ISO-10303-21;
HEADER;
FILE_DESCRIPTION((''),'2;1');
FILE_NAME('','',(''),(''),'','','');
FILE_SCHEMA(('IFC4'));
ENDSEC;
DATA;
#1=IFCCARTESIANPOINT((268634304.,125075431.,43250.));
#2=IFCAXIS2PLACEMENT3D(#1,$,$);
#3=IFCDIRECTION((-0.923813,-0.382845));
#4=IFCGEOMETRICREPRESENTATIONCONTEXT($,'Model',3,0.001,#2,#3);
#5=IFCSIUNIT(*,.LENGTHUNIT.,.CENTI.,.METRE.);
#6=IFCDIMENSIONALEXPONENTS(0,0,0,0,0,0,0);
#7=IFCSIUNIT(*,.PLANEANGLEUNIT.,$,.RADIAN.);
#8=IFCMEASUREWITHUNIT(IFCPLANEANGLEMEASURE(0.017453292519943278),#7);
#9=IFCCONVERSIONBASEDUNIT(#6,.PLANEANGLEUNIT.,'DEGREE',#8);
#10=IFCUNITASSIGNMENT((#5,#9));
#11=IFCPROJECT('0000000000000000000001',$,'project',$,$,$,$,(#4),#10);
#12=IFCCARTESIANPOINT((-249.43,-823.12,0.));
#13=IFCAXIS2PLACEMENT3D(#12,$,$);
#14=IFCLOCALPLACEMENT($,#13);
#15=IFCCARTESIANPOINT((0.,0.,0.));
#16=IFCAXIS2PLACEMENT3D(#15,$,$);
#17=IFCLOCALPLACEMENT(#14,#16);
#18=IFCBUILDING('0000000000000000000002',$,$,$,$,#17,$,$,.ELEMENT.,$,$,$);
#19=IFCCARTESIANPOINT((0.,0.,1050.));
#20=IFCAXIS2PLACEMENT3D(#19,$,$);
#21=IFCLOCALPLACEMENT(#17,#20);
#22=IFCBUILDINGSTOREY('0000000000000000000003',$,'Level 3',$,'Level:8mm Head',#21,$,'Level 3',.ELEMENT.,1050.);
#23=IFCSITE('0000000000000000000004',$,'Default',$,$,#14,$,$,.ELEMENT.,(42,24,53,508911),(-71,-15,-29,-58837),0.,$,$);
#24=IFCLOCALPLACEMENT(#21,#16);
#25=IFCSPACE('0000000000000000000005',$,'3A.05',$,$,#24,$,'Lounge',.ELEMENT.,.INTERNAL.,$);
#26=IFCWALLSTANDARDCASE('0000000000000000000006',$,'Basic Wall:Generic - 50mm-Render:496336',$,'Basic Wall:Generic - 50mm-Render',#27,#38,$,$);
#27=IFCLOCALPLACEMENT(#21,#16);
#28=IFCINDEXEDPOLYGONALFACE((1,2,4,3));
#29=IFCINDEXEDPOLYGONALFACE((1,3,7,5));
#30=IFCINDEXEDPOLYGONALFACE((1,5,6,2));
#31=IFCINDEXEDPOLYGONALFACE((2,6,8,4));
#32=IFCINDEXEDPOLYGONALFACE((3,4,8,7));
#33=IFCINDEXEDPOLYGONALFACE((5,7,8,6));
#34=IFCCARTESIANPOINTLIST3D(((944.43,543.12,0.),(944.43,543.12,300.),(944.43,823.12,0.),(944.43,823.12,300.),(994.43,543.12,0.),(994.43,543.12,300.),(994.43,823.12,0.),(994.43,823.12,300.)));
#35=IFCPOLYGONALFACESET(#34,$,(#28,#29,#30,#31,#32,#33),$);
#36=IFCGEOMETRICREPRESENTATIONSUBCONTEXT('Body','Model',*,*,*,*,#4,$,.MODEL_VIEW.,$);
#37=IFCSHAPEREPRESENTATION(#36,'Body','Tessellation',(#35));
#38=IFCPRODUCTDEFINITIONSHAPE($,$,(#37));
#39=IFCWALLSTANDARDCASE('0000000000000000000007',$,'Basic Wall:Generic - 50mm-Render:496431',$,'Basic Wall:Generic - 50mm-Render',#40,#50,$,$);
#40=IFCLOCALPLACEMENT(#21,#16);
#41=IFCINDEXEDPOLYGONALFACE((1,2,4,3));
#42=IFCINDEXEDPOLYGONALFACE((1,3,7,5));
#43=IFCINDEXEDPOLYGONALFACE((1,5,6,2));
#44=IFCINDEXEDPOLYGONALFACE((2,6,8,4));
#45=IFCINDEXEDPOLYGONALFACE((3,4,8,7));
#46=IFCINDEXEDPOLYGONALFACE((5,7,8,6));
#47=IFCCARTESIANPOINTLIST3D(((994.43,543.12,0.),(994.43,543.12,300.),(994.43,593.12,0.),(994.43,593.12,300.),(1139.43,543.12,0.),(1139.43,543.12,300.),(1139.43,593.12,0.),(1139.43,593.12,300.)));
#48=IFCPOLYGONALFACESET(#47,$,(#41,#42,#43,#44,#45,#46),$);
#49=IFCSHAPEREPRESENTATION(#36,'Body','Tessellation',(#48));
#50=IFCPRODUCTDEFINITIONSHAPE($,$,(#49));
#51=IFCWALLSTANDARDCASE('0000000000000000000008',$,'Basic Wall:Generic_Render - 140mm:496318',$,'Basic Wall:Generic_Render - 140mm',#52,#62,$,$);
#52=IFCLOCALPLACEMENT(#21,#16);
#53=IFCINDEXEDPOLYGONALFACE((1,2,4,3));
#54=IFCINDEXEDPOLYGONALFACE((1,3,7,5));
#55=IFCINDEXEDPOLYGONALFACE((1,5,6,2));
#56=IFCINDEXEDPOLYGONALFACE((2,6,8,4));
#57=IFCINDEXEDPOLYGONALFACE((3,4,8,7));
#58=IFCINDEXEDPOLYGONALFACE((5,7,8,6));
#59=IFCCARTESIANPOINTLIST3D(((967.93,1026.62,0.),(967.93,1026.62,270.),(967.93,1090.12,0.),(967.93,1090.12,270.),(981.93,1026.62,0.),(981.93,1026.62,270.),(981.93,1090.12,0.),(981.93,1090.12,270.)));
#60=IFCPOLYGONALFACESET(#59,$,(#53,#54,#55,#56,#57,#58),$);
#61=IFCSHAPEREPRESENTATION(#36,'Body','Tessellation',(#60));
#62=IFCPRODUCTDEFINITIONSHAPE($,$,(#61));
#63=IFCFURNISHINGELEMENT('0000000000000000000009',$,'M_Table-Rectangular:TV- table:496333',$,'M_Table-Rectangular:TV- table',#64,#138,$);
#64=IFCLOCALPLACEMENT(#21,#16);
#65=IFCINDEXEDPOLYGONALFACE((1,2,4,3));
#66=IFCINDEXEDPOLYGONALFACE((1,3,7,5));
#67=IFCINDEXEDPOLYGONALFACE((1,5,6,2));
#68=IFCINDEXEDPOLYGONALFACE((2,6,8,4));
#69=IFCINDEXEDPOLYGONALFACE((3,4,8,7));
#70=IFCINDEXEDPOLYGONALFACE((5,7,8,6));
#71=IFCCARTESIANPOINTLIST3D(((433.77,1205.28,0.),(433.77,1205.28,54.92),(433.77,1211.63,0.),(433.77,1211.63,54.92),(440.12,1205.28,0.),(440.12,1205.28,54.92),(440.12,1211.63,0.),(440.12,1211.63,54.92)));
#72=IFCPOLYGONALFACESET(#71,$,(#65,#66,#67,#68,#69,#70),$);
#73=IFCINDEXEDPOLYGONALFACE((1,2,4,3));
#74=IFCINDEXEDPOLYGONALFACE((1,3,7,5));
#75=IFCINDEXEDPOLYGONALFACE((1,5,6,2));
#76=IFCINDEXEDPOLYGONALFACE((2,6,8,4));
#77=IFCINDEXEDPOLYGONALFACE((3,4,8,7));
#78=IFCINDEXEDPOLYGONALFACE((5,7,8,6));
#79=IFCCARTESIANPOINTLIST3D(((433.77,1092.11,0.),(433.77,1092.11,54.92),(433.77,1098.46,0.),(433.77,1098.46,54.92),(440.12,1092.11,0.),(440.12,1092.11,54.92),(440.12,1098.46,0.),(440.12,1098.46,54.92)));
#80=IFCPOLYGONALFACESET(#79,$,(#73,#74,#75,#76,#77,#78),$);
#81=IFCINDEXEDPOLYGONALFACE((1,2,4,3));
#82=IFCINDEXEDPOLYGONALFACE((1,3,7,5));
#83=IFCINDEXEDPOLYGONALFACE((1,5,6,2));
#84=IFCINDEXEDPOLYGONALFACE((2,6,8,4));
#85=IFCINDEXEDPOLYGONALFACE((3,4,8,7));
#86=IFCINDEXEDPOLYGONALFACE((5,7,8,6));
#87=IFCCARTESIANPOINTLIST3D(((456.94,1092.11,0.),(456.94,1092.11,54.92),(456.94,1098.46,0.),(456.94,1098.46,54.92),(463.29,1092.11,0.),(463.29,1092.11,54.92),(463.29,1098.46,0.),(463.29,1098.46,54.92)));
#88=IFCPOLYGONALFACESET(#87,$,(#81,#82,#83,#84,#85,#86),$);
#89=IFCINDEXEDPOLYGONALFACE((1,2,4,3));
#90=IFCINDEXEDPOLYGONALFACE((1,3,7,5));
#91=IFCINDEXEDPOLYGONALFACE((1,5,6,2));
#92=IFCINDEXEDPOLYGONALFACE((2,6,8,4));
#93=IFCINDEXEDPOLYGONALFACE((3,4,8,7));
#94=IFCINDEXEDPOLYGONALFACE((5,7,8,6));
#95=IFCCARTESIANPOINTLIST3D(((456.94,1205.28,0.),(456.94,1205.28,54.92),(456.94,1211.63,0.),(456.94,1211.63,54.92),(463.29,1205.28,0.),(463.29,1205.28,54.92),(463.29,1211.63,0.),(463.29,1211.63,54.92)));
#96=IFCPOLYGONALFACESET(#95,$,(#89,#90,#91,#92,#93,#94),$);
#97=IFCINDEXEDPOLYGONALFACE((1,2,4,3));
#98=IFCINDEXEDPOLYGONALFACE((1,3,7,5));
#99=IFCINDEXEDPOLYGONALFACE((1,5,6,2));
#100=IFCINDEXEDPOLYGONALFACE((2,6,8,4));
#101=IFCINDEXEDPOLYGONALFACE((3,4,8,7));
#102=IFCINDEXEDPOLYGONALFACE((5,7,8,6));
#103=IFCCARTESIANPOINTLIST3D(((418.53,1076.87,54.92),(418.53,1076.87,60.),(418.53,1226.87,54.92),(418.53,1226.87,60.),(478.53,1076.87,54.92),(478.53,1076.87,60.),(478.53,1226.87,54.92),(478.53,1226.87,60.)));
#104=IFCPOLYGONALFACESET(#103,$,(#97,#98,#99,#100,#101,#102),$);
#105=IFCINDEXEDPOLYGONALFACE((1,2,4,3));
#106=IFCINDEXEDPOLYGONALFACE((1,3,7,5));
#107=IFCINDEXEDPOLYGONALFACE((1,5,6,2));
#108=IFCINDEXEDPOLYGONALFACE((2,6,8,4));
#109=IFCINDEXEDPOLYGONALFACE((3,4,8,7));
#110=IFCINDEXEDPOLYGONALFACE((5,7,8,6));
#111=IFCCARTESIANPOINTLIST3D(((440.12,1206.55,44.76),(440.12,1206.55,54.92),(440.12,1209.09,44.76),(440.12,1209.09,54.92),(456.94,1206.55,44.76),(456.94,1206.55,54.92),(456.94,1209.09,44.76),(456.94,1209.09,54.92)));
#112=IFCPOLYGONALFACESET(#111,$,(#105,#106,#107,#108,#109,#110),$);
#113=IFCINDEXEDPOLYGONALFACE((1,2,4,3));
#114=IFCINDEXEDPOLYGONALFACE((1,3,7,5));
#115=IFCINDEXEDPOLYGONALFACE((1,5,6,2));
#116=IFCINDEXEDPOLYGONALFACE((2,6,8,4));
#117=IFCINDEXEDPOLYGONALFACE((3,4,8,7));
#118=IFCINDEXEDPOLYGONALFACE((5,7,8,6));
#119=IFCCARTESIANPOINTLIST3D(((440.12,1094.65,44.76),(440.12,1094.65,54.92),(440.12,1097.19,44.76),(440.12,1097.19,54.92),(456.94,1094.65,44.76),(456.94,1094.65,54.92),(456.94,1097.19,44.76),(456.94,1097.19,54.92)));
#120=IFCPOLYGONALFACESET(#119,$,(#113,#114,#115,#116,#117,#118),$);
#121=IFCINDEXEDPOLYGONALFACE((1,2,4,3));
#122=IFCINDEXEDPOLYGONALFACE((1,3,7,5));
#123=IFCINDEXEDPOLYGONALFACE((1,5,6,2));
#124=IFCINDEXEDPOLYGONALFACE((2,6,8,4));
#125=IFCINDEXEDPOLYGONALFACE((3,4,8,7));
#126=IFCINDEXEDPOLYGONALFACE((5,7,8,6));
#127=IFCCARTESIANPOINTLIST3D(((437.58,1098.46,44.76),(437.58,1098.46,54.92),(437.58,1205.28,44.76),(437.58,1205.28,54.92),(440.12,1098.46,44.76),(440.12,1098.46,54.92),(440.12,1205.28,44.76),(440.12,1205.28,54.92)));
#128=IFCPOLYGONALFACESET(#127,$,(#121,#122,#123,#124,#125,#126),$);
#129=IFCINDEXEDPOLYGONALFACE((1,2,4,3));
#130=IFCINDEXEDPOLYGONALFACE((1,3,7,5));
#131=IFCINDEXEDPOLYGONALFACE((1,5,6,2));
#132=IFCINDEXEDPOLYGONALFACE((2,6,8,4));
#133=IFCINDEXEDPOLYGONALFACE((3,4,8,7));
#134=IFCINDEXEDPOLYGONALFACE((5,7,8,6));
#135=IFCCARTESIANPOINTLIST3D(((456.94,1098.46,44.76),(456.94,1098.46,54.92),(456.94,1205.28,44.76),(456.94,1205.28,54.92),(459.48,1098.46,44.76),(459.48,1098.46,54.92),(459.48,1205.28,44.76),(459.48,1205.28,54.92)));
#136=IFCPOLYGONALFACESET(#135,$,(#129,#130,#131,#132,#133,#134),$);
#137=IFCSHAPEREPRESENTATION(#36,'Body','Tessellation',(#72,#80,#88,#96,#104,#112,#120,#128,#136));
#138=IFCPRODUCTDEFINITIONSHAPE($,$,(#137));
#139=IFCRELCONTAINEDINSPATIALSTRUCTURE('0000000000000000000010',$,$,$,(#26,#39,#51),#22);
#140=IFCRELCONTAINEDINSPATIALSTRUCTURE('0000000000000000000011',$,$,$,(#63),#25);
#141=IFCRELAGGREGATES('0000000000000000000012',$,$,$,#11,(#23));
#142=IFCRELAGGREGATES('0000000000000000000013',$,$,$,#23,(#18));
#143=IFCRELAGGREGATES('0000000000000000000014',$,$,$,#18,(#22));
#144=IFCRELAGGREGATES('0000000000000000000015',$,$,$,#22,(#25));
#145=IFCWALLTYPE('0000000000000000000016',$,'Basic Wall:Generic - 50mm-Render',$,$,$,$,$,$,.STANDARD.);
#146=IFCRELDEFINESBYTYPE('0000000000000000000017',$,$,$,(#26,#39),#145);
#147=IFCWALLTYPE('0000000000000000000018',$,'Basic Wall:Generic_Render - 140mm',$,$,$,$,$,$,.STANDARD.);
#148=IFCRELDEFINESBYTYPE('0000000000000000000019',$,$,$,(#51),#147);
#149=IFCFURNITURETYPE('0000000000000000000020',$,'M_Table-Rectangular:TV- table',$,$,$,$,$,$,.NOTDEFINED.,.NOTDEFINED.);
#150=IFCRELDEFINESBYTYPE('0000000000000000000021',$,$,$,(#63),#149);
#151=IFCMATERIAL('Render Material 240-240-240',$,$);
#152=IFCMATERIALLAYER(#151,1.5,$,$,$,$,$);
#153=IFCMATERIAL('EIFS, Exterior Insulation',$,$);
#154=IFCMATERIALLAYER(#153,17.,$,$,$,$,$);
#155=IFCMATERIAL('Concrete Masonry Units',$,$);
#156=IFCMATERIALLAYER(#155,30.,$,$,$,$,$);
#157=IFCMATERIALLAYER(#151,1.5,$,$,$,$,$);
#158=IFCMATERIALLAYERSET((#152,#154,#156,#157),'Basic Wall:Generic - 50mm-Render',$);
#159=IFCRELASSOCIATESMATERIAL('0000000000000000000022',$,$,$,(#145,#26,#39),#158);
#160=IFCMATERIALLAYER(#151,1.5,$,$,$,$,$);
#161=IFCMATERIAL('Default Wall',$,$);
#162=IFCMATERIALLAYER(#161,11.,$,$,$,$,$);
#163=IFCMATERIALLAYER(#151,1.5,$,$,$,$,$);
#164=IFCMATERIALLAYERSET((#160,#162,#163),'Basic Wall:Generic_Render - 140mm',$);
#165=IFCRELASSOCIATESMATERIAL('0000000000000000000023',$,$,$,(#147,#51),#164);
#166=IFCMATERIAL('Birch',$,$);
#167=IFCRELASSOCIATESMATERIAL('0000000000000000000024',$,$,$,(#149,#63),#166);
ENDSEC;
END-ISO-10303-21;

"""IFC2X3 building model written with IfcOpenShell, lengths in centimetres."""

from ifc_helpers import new_model, entity, si_unit, converted_unit, direction, frame, frame_2d, origin, origin_2d_with_axis, place, context, subcontext, project, spatial, rectangle, extrude, source, transform, mapped, material, layer, layer_set, layer_usage, type_object, type_shapes, element, save


model = new_model("IFC2X3")

# Units and contexts
model_context = context("Model", 3, precision=0.001, world=frame((268634304.0, 125075431.0, 43250.0)), true_north=direction((-0.923813, -0.382845)))
body_context = subcontext(model_context, "Body", "Model", "MODEL_VIEW")
ifc_project = project(units=[si_unit("LENGTHUNIT", "METRE", prefix="CENTI"), converted_unit("PLANEANGLEUNIT", "DEGREE", entity("IfcPlaneAngleMeasure", 0.017453292519943278), si_unit("PLANEANGLEUNIT", "RADIAN"), dimensions=[0, 0, 0, 0, 0, 0, 0])], contexts=[model_context])

# Site, building, storey
site_placement = place(None, frame((-249.43, -823.12, 0.0)))
site = spatial("IfcSite", under=ifc_project, at=site_placement, Name="Default", CompositionType="ELEMENT", RefLatitude=(42, 24, 53, 508911), RefLongitude=(-71, -15, -29, -58837), RefElevation=0.0)
building_placement = place(site_placement, origin())
building = spatial("IfcBuilding", under=site, at=building_placement, CompositionType="ELEMENT")
storey_placement = place(building_placement, frame((0.0, 0.0, 1050.0)))
storey = spatial("IfcBuildingStorey", under=building, at=storey_placement, Name="Level 3", ObjectType="Level:8mm Head", LongName="Level 3", CompositionType="ELEMENT", Elevation=1050.0)

# Walls
ifc_material_1 = material(Name="Render Material 240-240-240")
ifc_layer_1 = layer(ifc_material_1, 1.5)
ifc_material_2 = material(Name="EIFS, Exterior Insulation")
ifc_layer_2 = layer(ifc_material_2, 17.0)
ifc_material_3 = material(Name="Concrete Masonry Units")
ifc_layer_3 = layer(ifc_material_3, 30.0)
ifc_layer_4 = layer(ifc_material_1, 1.5)
ifc_layer_set_1 = layer_set([ifc_layer_1, ifc_layer_2, ifc_layer_3, ifc_layer_4], Name="Basic Wall:Generic - 50mm-Render")
ifc_layer_usage_1 = layer_usage(ifc_layer_set_1, "AXIS2", "POSITIVE", -25.0)
wall_type_1 = type_object("IfcWallType", Name="Basic Wall:Generic - 50mm-Render", PredefinedType="STANDARD", material=ifc_layer_set_1)
wall_1_placement = place(storey_placement, frame((969.43, 823.12, 0.0), z_axis=(0.0, 0.0, 1.0), x_axis=(0.0, -1.0, 0.0)))
element("IfcWallStandardCase", 1, at=wall_1_placement, inside=storey, type_object=wall_type_1, material=ifc_layer_usage_1, Name="Basic Wall:Generic - 50mm-Render:496336", ObjectType="Basic Wall:Generic - 50mm-Render", context=body_context, shape_type="SweptSolid", body=[
    extrude(rectangle(XDim=280.0, YDim=50.0, at=frame_2d((140.0, 0.0), x_axis=(-1.0, 0.0))), origin(), (0.0, 0.0, 1.0), 300.0),
])
ifc_layer_usage_2 = layer_usage(ifc_layer_set_1, "AXIS2", "NEGATIVE", 25.0)
wall_2_placement = place(storey_placement, frame((1139.43, 568.12, 0.0), z_axis=(0.0, 0.0, 1.0), x_axis=(-1.0, 0.0, 0.0)))
element("IfcWallStandardCase", 2, at=wall_2_placement, inside=storey, type_object=wall_type_1, material=ifc_layer_usage_2, Name="Basic Wall:Generic - 50mm-Render:496431", ObjectType="Basic Wall:Generic - 50mm-Render", context=body_context, shape_type="SweptSolid", body=[
    extrude(rectangle(XDim=145.0, YDim=50.0, at=frame_2d((72.5, 0.0), x_axis=(-1.0, 0.0))), origin(), (0.0, 0.0, 1.0), 300.0),
])
ifc_layer_5 = layer(ifc_material_1, 1.5)
ifc_material_4 = material(Name="Default Wall")
ifc_layer_6 = layer(ifc_material_4, 11.0)
ifc_layer_7 = layer(ifc_material_1, 1.5)
ifc_layer_set_2 = layer_set([ifc_layer_5, ifc_layer_6, ifc_layer_7], Name="Basic Wall:Generic_Render - 140mm")
ifc_layer_usage_3 = layer_usage(ifc_layer_set_2, "AXIS2", "NEGATIVE", 7.0)
wall_type_2 = type_object("IfcWallType", Name="Basic Wall:Generic_Render - 140mm", PredefinedType="STANDARD", material=ifc_layer_set_2)
wall_3_placement = place(storey_placement, frame((974.93, 1090.12, 0.0), z_axis=(0.0, 0.0, 1.0), x_axis=(0.0, -1.0, 0.0)))
element("IfcWallStandardCase", 3, at=wall_3_placement, inside=storey, type_object=wall_type_2, material=ifc_layer_usage_3, Name="Basic Wall:Generic_Render - 140mm:496318", ObjectType="Basic Wall:Generic_Render - 140mm", context=body_context, shape_type="SweptSolid", body=[
    extrude(rectangle(XDim=63.5, YDim=14.0, at=frame_2d((31.75, 0.0), x_axis=(-1.0, 0.0))), origin(), (0.0, 0.0, 1.0), 270.0),
])

# Shared definitions
space_1_placement = place(storey_placement, origin())
space_1 = spatial("IfcSpace", under=storey, at=space_1_placement, Name="3A.05", LongName="Lounge", CompositionType="ELEMENT", InteriorOrExteriorSpace="INTERNAL")

# Furnishing element
ifc_material_5 = material(Name="Birch")
furniture_type_1 = type_object("IfcFurnitureType", Name="M_Table-Rectangular:TV- table", AssemblyPlace="NOTDEFINED", material=ifc_material_5)
shared_shape_1 = source(origin(), body_context, "Body", "SweptSolid", [
    extrude(rectangle(XDim=6.35, YDim=6.35, at=origin_2d_with_axis()), frame((56.58, 11.59, 0.0), z_axis=(0.0, 0.0, 1.0), x_axis=(0.0, -1.0, 0.0)), (0.0, 0.0, 1.0), 54.92),
    extrude(rectangle(XDim=6.35, YDim=6.35, at=frame_2d((0.0, 0.0), x_axis=(1.0, 0.0))), frame((-56.58, 11.59, 0.0), z_axis=(0.0, 0.0, 1.0), x_axis=(-1.0, 0.0, 0.0)), (0.0, 0.0, 1.0), 54.92),
    extrude(rectangle(XDim=6.35, YDim=6.35, at=origin_2d_with_axis()), frame((-56.58, -11.59, 0.0), z_axis=(0.0, 0.0, 1.0), x_axis=(0.0, 1.0, 0.0)), (0.0, 0.0, 1.0), 54.92),
    extrude(rectangle(XDim=6.35, YDim=6.35, at=origin_2d_with_axis()), frame((56.58, -11.59, 0.0)), (0.0, 0.0, 1.0), 54.92),
    extrude(rectangle(XDim=150.0, YDim=60.0, at=origin_2d_with_axis()), frame((0.0, 0.0, 54.92), z_axis=(0.0, 0.0, 1.0), x_axis=(-1.0, 0.0, 0.0)), (0.0, 0.0, 1.0), 5.08),
    extrude(rectangle(XDim=2.54, YDim=16.82, at=origin_2d_with_axis()), frame((55.95, 0.0, 44.76)), (0.0, 0.0, 1.0), 10.16),
    extrude(rectangle(XDim=16.82, YDim=2.54, at=origin_2d_with_axis()), frame((-55.95, 0.0, 44.76), z_axis=(0.0, 0.0, 1.0), x_axis=(0.0, 1.0, 0.0)), (0.0, 0.0, 1.0), 10.16),
    extrude(rectangle(XDim=106.82, YDim=2.54, at=frame_2d((0.0, 0.0), x_axis=(1.0, 0.0))), frame((0.0, 9.68, 44.76), z_axis=(0.0, 0.0, 1.0), x_axis=(-1.0, 0.0, 0.0)), (0.0, 0.0, 1.0), 10.16),
    extrude(rectangle(XDim=2.54, YDim=106.82, at=origin_2d_with_axis()), frame((0.0, -9.68, 44.76), z_axis=(0.0, 0.0, 1.0), x_axis=(0.0, 1.0, 0.0)), (0.0, 0.0, 1.0), 10.16),
])
type_shapes(furniture_type_1, [shared_shape_1])
furnishing_1_placement = place(space_1_placement, frame((448.53, 1151.87, 0.0), z_axis=(0.0, 0.0, 1.0), x_axis=(0.0, 1.0, 0.0)))
element("IfcFurnishingElement", 4, at=furnishing_1_placement, inside=space_1, type_object=furniture_type_1, material=ifc_material_5, Name="M_Table-Rectangular:TV- table:496333", ObjectType="M_Table-Rectangular:TV- table", context=body_context, shape_type="MappedRepresentation", body=[
    mapped(shared_shape_1, transform((0.0, 0.0, 0.0), scale=1.0)),
])

save(model, "model.ifc")
